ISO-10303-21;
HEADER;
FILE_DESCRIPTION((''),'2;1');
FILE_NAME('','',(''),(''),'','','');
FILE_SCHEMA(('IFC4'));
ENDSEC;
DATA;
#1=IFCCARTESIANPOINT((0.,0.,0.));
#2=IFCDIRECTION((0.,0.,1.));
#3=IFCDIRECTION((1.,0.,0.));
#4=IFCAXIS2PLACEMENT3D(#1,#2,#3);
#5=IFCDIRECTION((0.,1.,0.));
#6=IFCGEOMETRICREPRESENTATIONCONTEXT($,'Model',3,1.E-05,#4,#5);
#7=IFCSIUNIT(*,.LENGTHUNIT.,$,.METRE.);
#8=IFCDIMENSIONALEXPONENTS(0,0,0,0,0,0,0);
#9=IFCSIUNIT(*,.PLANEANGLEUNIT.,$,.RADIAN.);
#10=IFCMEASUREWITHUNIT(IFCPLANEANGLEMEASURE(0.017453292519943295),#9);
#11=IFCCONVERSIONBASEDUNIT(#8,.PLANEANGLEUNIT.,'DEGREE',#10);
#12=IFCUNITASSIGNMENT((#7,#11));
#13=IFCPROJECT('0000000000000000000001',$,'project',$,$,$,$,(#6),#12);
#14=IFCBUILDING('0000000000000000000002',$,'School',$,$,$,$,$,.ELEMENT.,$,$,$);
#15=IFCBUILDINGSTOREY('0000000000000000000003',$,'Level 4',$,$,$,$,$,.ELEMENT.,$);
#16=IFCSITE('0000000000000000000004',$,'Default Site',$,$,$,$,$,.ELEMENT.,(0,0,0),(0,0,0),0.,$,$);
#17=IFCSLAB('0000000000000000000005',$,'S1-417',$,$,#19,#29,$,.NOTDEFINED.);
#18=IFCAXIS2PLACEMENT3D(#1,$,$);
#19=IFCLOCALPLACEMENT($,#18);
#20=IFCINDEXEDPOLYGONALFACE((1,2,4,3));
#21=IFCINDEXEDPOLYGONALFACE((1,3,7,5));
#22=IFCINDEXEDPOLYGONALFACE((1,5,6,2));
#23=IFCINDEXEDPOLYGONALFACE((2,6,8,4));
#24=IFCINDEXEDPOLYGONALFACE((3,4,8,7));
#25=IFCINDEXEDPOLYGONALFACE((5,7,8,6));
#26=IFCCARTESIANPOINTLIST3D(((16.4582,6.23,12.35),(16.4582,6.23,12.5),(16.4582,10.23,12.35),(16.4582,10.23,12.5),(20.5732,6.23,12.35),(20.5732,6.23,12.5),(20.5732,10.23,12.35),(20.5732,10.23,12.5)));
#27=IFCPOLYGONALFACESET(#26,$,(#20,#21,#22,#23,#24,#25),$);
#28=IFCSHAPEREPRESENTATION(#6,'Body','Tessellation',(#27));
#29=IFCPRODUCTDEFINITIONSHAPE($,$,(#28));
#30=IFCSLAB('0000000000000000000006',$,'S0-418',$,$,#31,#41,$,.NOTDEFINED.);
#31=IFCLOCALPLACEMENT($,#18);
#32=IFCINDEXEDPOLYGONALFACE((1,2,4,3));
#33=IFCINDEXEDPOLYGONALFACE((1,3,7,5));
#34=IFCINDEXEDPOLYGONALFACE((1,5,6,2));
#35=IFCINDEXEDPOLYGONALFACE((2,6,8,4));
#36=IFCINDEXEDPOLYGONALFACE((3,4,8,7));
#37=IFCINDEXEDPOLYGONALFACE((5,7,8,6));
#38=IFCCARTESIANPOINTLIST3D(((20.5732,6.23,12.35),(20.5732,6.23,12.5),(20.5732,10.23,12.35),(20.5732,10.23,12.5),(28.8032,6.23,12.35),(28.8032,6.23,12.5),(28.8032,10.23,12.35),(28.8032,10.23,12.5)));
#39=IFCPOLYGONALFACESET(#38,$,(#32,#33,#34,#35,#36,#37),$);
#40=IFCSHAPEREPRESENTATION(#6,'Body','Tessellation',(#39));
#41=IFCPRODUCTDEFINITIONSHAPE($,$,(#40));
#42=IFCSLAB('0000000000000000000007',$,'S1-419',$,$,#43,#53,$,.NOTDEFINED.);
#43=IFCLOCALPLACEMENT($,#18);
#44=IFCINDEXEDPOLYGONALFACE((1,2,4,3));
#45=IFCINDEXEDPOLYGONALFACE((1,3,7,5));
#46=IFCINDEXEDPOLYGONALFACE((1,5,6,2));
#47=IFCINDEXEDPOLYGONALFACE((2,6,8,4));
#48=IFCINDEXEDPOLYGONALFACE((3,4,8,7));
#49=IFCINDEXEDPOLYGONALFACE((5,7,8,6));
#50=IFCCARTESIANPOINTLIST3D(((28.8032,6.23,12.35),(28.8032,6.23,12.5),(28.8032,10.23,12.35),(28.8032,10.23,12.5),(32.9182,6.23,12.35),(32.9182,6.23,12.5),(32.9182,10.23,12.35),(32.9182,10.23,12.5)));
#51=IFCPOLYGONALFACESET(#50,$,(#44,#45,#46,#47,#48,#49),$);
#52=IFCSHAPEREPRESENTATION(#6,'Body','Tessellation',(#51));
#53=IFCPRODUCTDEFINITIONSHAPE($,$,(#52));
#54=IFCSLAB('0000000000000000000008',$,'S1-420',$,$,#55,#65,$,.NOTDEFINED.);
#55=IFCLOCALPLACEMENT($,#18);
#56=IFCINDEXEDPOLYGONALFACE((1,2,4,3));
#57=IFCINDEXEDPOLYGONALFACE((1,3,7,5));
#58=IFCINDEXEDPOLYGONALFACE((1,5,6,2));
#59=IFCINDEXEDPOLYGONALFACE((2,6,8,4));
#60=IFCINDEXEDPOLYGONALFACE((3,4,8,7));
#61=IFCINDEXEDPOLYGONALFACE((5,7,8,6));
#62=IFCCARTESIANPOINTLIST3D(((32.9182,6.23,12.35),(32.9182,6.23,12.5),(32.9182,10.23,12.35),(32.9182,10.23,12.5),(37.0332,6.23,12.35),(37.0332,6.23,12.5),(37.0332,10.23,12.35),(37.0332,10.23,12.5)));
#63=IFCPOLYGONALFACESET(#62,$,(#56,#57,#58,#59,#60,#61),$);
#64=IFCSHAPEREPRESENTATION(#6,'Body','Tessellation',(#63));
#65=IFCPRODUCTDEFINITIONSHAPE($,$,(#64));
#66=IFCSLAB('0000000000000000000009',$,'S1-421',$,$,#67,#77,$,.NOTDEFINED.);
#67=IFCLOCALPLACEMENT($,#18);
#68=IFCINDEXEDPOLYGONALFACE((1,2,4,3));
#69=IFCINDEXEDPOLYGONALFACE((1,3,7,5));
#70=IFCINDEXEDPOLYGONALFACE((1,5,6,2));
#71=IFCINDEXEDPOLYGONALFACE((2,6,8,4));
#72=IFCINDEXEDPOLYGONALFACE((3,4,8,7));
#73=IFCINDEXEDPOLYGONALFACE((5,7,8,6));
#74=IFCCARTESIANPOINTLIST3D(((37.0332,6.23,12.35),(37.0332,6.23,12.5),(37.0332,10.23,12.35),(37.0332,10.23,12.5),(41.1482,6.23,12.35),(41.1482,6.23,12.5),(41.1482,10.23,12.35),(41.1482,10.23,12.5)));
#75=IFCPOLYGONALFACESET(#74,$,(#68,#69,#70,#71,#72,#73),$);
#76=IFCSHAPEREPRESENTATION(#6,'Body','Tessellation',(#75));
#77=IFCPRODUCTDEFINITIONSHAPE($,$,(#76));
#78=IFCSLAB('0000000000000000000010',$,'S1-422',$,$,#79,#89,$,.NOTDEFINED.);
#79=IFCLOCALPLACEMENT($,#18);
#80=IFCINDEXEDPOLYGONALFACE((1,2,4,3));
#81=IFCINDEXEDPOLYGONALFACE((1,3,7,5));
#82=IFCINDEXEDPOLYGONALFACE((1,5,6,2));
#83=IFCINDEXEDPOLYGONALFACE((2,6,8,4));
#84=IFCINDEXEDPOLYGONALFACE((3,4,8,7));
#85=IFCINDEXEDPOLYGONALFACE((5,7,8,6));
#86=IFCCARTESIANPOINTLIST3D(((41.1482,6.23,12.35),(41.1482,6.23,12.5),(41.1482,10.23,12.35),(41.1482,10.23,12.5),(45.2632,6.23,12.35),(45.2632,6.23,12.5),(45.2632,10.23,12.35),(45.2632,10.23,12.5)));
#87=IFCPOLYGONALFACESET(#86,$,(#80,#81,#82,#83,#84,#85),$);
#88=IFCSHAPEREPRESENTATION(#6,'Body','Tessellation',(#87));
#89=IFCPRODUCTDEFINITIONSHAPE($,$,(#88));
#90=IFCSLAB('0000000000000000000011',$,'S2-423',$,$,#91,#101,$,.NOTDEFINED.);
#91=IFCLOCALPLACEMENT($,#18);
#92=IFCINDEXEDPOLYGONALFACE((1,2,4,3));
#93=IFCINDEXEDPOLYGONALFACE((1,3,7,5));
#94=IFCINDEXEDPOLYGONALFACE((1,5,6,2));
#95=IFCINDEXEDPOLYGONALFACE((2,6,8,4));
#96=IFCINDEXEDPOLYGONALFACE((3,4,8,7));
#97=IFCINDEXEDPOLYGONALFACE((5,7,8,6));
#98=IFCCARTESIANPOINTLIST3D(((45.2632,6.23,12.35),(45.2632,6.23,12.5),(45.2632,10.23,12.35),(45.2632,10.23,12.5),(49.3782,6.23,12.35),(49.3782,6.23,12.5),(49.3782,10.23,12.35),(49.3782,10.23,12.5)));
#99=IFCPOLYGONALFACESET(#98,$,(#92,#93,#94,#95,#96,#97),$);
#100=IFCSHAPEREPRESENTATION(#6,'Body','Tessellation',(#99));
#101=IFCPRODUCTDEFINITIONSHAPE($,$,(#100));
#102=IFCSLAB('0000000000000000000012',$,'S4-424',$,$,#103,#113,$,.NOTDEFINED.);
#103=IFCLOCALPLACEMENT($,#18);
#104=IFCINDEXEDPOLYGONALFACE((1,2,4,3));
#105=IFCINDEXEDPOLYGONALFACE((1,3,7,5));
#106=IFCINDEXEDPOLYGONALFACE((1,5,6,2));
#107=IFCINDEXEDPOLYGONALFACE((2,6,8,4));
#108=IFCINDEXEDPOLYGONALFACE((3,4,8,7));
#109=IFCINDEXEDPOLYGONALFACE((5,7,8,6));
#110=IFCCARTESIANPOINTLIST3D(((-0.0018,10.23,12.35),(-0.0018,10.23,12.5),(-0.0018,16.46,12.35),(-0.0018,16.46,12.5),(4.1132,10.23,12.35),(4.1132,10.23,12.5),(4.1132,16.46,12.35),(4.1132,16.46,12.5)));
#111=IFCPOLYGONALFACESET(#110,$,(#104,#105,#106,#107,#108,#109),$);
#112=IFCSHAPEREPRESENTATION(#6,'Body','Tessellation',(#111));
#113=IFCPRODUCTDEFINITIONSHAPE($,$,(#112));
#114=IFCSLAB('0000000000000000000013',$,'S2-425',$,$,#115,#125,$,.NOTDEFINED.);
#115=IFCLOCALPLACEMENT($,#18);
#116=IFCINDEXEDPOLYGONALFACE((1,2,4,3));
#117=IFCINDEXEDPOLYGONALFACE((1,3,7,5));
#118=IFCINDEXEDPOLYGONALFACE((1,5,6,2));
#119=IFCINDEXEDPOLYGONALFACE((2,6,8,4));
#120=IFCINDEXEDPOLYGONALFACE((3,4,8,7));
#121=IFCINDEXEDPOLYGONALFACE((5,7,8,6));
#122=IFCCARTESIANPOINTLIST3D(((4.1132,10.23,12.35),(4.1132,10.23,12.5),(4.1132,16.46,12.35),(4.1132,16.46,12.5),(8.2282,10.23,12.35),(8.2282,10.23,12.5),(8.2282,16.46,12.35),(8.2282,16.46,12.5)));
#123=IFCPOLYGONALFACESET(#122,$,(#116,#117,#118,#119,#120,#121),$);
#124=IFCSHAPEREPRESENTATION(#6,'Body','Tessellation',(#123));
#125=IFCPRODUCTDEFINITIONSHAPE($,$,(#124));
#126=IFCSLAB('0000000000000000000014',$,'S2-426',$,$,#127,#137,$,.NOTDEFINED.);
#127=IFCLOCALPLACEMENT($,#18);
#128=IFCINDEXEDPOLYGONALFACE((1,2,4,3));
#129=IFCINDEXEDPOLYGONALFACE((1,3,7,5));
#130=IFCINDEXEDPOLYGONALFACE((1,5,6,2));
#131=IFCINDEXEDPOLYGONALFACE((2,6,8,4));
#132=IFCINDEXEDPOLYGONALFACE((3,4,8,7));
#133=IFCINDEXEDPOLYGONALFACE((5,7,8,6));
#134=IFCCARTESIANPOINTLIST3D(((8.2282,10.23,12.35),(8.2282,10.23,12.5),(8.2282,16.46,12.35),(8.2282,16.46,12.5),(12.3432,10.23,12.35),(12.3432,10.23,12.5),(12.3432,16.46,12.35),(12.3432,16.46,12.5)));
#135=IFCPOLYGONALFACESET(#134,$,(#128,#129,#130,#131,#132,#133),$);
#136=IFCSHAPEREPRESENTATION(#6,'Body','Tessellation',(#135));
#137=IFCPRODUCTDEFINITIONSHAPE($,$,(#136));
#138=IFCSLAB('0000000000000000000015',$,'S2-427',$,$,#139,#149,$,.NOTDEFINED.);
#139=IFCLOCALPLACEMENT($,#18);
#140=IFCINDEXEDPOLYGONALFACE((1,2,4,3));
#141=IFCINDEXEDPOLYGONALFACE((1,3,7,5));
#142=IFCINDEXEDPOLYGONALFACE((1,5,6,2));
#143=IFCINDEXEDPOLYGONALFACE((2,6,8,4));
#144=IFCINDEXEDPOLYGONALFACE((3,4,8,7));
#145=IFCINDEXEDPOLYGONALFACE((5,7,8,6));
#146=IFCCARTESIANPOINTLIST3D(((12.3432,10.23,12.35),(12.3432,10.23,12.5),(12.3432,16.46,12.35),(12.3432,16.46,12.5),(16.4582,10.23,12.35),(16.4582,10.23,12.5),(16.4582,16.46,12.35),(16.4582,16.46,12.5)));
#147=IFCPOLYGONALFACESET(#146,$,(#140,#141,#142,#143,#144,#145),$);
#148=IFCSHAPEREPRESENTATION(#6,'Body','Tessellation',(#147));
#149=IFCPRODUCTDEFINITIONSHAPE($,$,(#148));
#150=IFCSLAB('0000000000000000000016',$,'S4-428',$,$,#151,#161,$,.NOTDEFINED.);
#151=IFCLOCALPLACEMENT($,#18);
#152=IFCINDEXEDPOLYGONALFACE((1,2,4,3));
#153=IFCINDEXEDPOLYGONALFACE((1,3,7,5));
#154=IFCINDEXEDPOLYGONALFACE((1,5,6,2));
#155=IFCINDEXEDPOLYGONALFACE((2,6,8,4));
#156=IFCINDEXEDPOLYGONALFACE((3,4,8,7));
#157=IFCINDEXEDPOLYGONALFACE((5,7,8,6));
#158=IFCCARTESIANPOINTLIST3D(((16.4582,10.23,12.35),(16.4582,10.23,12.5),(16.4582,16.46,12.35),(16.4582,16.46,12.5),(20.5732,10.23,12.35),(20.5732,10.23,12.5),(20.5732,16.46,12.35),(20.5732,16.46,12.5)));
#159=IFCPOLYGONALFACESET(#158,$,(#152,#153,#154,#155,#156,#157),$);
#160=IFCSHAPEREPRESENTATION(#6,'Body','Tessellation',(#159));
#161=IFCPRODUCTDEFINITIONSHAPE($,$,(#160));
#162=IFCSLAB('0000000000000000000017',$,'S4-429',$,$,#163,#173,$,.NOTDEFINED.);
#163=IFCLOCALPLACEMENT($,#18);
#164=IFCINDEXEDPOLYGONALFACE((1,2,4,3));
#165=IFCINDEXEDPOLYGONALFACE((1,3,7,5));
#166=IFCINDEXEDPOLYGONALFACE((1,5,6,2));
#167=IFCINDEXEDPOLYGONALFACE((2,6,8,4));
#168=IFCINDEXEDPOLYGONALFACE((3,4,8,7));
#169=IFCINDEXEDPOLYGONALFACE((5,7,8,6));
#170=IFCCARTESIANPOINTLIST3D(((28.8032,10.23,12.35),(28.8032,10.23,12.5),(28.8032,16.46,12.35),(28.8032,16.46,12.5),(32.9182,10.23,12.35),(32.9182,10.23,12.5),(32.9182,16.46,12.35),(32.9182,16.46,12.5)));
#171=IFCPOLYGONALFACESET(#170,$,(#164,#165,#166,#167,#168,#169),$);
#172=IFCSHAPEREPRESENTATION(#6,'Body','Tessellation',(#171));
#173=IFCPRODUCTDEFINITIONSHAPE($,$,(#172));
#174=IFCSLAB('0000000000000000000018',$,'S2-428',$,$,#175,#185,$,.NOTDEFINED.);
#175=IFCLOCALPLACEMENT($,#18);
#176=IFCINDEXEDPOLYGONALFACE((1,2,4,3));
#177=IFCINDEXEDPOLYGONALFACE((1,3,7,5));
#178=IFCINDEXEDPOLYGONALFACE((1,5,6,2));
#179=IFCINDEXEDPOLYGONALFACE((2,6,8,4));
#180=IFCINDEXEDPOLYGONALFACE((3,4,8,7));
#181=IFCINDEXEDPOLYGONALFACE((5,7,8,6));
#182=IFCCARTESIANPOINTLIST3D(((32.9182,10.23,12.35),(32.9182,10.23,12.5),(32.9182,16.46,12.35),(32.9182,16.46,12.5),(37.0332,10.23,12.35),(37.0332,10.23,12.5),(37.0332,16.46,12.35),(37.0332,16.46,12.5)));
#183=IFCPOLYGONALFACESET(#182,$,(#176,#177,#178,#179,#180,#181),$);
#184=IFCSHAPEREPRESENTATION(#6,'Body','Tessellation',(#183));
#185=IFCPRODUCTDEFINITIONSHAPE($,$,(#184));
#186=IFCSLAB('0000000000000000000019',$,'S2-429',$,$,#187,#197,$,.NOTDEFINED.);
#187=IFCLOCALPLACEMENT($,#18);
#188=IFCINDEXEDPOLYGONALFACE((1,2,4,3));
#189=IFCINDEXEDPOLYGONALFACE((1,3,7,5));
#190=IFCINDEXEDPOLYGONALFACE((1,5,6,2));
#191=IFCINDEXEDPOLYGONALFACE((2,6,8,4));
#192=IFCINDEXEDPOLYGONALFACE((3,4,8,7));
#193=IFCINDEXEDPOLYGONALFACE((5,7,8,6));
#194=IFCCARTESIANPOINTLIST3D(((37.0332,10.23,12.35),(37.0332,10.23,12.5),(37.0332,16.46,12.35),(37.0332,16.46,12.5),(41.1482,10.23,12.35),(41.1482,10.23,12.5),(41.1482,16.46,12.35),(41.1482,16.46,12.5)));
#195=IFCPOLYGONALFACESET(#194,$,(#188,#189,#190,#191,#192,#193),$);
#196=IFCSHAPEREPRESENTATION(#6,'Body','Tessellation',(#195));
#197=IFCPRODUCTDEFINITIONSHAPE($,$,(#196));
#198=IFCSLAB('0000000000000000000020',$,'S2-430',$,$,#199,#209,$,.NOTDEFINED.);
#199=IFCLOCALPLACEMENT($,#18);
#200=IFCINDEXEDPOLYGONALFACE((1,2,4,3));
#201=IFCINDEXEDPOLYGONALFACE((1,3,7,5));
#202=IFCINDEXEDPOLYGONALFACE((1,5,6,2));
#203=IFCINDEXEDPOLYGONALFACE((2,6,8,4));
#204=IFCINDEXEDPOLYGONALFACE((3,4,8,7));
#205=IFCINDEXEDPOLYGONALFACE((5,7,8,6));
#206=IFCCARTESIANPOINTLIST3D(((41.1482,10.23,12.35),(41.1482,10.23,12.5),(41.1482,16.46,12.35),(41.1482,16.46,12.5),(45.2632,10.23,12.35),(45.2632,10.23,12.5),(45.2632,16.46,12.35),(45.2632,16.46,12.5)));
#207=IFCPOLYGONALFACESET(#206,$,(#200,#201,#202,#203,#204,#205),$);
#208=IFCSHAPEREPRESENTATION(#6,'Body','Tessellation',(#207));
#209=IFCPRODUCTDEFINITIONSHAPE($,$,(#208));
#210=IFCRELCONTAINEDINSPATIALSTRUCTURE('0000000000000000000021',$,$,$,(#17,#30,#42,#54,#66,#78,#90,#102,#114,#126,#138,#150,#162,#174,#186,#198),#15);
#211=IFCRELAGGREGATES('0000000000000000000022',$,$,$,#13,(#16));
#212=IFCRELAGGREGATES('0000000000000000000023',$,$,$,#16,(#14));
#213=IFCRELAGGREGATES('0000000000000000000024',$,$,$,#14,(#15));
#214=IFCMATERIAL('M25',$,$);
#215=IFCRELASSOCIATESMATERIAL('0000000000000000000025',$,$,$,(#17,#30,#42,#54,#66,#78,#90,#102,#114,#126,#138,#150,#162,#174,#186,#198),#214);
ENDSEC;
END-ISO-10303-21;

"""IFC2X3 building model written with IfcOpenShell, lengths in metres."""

from ifc_helpers import new_model, entity, si_unit, converted_unit, direction, frame, frame_2d, origin_with_axes, place, context, project, spatial, rectangle, extrude, material, element, save


model = new_model("IFC2X3")

# Units and contexts
model_context = context("Model", 3, precision=1e-05, world=origin_with_axes(), true_north=direction((0.0, 1.0, 0.0)))
ifc_project = project(units=[si_unit("LENGTHUNIT", "METRE"), converted_unit("PLANEANGLEUNIT", "DEGREE", entity("IfcPlaneAngleMeasure", 0.017453292519943295), si_unit("PLANEANGLEUNIT", "RADIAN"), dimensions=[0, 0, 0, 0, 0, 0, 0])], contexts=[model_context])

# Site, building, storey
site = spatial("IfcSite", under=ifc_project, Name="Default Site", CompositionType="ELEMENT", RefLatitude=(0, 0, 0), RefLongitude=(0, 0, 0), RefElevation=0.0)
building = spatial("IfcBuilding", under=site, Name="School", CompositionType="ELEMENT")
storey = spatial("IfcBuildingStorey", under=building, Name="Level 4", CompositionType="ELEMENT")

# Slabs
ifc_material = material(Name="M25")
placement = place(None, origin_with_axes())
element("IfcSlab", 1, at=placement, inside=storey, material=ifc_material, Name="S1-417", PredefinedType="NOTDEFINED", context=model_context, shape_type="SweptSolid", body=[
    extrude(rectangle(XDim=4.115, YDim=4.0, at=frame_2d((0.0, 0.0), x_axis=(1.0, 0.0, 0.0))), frame((18.5157, 8.23, 12.35), z_axis=(0.0, 0.0, 1.0), x_axis=(1.0, 0.0, 0.0)), (0.0, 0.0, 1.0), 0.15),
])
element("IfcSlab", 2, at=placement, inside=storey, material=ifc_material, Name="S0-418", PredefinedType="NOTDEFINED", context=model_context, shape_type="SweptSolid", body=[
    extrude(rectangle(XDim=8.23, YDim=4.0, at=frame_2d((0.0, 0.0), x_axis=(1.0, 0.0, 0.0))), frame((24.6882, 8.23, 12.35), z_axis=(0.0, 0.0, 1.0), x_axis=(1.0, 0.0, 0.0)), (0.0, 0.0, 1.0), 0.15),
])
element("IfcSlab", 3, at=placement, inside=storey, material=ifc_material, Name="S1-419", PredefinedType="NOTDEFINED", context=model_context, shape_type="SweptSolid", body=[
    extrude(rectangle(XDim=4.115, YDim=4.0, at=frame_2d((0.0, 0.0), x_axis=(1.0, 0.0, 0.0))), frame((30.8607, 8.23, 12.35), z_axis=(0.0, 0.0, 1.0), x_axis=(1.0, 0.0, 0.0)), (0.0, 0.0, 1.0), 0.15),
])
element("IfcSlab", 4, at=placement, inside=storey, material=ifc_material, Name="S1-420", PredefinedType="NOTDEFINED", context=model_context, shape_type="SweptSolid", body=[
    extrude(rectangle(XDim=4.115, YDim=4.0, at=frame_2d((0.0, 0.0), x_axis=(1.0, 0.0, 0.0))), frame((34.9757, 8.23, 12.35), z_axis=(0.0, 0.0, 1.0), x_axis=(1.0, 0.0, 0.0)), (0.0, 0.0, 1.0), 0.15),
])
element("IfcSlab", 5, at=placement, inside=storey, material=ifc_material, Name="S1-421", PredefinedType="NOTDEFINED", context=model_context, shape_type="SweptSolid", body=[
    extrude(rectangle(XDim=4.115, YDim=4.0, at=frame_2d((0.0, 0.0), x_axis=(1.0, 0.0, 0.0))), frame((39.0907, 8.23, 12.35), z_axis=(0.0, 0.0, 1.0), x_axis=(1.0, 0.0, 0.0)), (0.0, 0.0, 1.0), 0.15),
])
element("IfcSlab", 6, at=placement, inside=storey, material=ifc_material, Name="S1-422", PredefinedType="NOTDEFINED", context=model_context, shape_type="SweptSolid", body=[
    extrude(rectangle(XDim=4.115, YDim=4.0, at=frame_2d((0.0, 0.0), x_axis=(1.0, 0.0, 0.0))), frame((43.2057, 8.23, 12.35), z_axis=(0.0, 0.0, 1.0), x_axis=(1.0, 0.0, 0.0)), (0.0, 0.0, 1.0), 0.15),
])
element("IfcSlab", 7, at=placement, inside=storey, material=ifc_material, Name="S2-423", PredefinedType="NOTDEFINED", context=model_context, shape_type="SweptSolid", body=[
    extrude(rectangle(XDim=4.115, YDim=4.0, at=frame_2d((0.0, 0.0), x_axis=(1.0, 0.0, 0.0))), frame((47.3207, 8.23, 12.35), z_axis=(0.0, 0.0, 1.0), x_axis=(1.0, 0.0, 0.0)), (0.0, 0.0, 1.0), 0.15),
])
element("IfcSlab", 8, at=placement, inside=storey, material=ifc_material, Name="S4-424", PredefinedType="NOTDEFINED", context=model_context, shape_type="SweptSolid", body=[
    extrude(rectangle(XDim=4.115, YDim=6.23, at=frame_2d((0.0, 0.0), x_axis=(1.0, 0.0, 0.0))), frame((2.0557, 13.345, 12.35), z_axis=(0.0, 0.0, 1.0), x_axis=(1.0, 0.0, 0.0)), (0.0, 0.0, 1.0), 0.15),
])
element("IfcSlab", 9, at=placement, inside=storey, material=ifc_material, Name="S2-425", PredefinedType="NOTDEFINED", context=model_context, shape_type="SweptSolid", body=[
    extrude(rectangle(XDim=4.115, YDim=6.23, at=frame_2d((0.0, 0.0), x_axis=(1.0, 0.0, 0.0))), frame((6.1707, 13.345, 12.35), z_axis=(0.0, 0.0, 1.0), x_axis=(1.0, 0.0, 0.0)), (0.0, 0.0, 1.0), 0.15),
])
element("IfcSlab", 10, at=placement, inside=storey, material=ifc_material, Name="S2-426", PredefinedType="NOTDEFINED", context=model_context, shape_type="SweptSolid", body=[
    extrude(rectangle(XDim=4.115, YDim=6.23, at=frame_2d((0.0, 0.0), x_axis=(1.0, 0.0, 0.0))), frame((10.2857, 13.345, 12.35), z_axis=(0.0, 0.0, 1.0), x_axis=(1.0, 0.0, 0.0)), (0.0, 0.0, 1.0), 0.15),
])
element("IfcSlab", 11, at=placement, inside=storey, material=ifc_material, Name="S2-427", PredefinedType="NOTDEFINED", context=model_context, shape_type="SweptSolid", body=[
    extrude(rectangle(XDim=4.115, YDim=6.23, at=frame_2d((0.0, 0.0), x_axis=(1.0, 0.0, 0.0))), frame((14.4007, 13.345, 12.35), z_axis=(0.0, 0.0, 1.0), x_axis=(1.0, 0.0, 0.0)), (0.0, 0.0, 1.0), 0.15),
])
element("IfcSlab", 12, at=placement, inside=storey, material=ifc_material, Name="S4-428", PredefinedType="NOTDEFINED", context=model_context, shape_type="SweptSolid", body=[
    extrude(rectangle(XDim=4.115, YDim=6.23, at=frame_2d((0.0, 0.0), x_axis=(1.0, 0.0, 0.0))), frame((18.5157, 13.345, 12.35), z_axis=(0.0, 0.0, 1.0), x_axis=(1.0, 0.0, 0.0)), (0.0, 0.0, 1.0), 0.15),
])
element("IfcSlab", 13, at=placement, inside=storey, material=ifc_material, Name="S4-429", PredefinedType="NOTDEFINED", context=model_context, shape_type="SweptSolid", body=[
    extrude(rectangle(XDim=4.115, YDim=6.23, at=frame_2d((0.0, 0.0), x_axis=(1.0, 0.0, 0.0))), frame((30.8607, 13.345, 12.35), z_axis=(0.0, 0.0, 1.0), x_axis=(1.0, 0.0, 0.0)), (0.0, 0.0, 1.0), 0.15),
])
element("IfcSlab", 14, at=placement, inside=storey, material=ifc_material, Name="S2-428", PredefinedType="NOTDEFINED", context=model_context, shape_type="SweptSolid", body=[
    extrude(rectangle(XDim=4.115, YDim=6.23, at=frame_2d((0.0, 0.0), x_axis=(1.0, 0.0, 0.0))), frame((34.9757, 13.345, 12.35), z_axis=(0.0, 0.0, 1.0), x_axis=(1.0, 0.0, 0.0)), (0.0, 0.0, 1.0), 0.15),
])
element("IfcSlab", 15, at=placement, inside=storey, material=ifc_material, Name="S2-429", PredefinedType="NOTDEFINED", context=model_context, shape_type="SweptSolid", body=[
    extrude(rectangle(XDim=4.115, YDim=6.23, at=frame_2d((0.0, 0.0), x_axis=(1.0, 0.0, 0.0))), frame((39.0907, 13.345, 12.35), z_axis=(0.0, 0.0, 1.0), x_axis=(1.0, 0.0, 0.0)), (0.0, 0.0, 1.0), 0.15),
])
element("IfcSlab", 16, at=placement, inside=storey, material=ifc_material, Name="S2-430", PredefinedType="NOTDEFINED", context=model_context, shape_type="SweptSolid", body=[
    extrude(rectangle(XDim=4.115, YDim=6.23, at=frame_2d((0.0, 0.0), x_axis=(1.0, 0.0, 0.0))), frame((43.2057, 13.345, 12.35), z_axis=(0.0, 0.0, 1.0), x_axis=(1.0, 0.0, 0.0)), (0.0, 0.0, 1.0), 0.15),
])

save(model, "model.ifc")
